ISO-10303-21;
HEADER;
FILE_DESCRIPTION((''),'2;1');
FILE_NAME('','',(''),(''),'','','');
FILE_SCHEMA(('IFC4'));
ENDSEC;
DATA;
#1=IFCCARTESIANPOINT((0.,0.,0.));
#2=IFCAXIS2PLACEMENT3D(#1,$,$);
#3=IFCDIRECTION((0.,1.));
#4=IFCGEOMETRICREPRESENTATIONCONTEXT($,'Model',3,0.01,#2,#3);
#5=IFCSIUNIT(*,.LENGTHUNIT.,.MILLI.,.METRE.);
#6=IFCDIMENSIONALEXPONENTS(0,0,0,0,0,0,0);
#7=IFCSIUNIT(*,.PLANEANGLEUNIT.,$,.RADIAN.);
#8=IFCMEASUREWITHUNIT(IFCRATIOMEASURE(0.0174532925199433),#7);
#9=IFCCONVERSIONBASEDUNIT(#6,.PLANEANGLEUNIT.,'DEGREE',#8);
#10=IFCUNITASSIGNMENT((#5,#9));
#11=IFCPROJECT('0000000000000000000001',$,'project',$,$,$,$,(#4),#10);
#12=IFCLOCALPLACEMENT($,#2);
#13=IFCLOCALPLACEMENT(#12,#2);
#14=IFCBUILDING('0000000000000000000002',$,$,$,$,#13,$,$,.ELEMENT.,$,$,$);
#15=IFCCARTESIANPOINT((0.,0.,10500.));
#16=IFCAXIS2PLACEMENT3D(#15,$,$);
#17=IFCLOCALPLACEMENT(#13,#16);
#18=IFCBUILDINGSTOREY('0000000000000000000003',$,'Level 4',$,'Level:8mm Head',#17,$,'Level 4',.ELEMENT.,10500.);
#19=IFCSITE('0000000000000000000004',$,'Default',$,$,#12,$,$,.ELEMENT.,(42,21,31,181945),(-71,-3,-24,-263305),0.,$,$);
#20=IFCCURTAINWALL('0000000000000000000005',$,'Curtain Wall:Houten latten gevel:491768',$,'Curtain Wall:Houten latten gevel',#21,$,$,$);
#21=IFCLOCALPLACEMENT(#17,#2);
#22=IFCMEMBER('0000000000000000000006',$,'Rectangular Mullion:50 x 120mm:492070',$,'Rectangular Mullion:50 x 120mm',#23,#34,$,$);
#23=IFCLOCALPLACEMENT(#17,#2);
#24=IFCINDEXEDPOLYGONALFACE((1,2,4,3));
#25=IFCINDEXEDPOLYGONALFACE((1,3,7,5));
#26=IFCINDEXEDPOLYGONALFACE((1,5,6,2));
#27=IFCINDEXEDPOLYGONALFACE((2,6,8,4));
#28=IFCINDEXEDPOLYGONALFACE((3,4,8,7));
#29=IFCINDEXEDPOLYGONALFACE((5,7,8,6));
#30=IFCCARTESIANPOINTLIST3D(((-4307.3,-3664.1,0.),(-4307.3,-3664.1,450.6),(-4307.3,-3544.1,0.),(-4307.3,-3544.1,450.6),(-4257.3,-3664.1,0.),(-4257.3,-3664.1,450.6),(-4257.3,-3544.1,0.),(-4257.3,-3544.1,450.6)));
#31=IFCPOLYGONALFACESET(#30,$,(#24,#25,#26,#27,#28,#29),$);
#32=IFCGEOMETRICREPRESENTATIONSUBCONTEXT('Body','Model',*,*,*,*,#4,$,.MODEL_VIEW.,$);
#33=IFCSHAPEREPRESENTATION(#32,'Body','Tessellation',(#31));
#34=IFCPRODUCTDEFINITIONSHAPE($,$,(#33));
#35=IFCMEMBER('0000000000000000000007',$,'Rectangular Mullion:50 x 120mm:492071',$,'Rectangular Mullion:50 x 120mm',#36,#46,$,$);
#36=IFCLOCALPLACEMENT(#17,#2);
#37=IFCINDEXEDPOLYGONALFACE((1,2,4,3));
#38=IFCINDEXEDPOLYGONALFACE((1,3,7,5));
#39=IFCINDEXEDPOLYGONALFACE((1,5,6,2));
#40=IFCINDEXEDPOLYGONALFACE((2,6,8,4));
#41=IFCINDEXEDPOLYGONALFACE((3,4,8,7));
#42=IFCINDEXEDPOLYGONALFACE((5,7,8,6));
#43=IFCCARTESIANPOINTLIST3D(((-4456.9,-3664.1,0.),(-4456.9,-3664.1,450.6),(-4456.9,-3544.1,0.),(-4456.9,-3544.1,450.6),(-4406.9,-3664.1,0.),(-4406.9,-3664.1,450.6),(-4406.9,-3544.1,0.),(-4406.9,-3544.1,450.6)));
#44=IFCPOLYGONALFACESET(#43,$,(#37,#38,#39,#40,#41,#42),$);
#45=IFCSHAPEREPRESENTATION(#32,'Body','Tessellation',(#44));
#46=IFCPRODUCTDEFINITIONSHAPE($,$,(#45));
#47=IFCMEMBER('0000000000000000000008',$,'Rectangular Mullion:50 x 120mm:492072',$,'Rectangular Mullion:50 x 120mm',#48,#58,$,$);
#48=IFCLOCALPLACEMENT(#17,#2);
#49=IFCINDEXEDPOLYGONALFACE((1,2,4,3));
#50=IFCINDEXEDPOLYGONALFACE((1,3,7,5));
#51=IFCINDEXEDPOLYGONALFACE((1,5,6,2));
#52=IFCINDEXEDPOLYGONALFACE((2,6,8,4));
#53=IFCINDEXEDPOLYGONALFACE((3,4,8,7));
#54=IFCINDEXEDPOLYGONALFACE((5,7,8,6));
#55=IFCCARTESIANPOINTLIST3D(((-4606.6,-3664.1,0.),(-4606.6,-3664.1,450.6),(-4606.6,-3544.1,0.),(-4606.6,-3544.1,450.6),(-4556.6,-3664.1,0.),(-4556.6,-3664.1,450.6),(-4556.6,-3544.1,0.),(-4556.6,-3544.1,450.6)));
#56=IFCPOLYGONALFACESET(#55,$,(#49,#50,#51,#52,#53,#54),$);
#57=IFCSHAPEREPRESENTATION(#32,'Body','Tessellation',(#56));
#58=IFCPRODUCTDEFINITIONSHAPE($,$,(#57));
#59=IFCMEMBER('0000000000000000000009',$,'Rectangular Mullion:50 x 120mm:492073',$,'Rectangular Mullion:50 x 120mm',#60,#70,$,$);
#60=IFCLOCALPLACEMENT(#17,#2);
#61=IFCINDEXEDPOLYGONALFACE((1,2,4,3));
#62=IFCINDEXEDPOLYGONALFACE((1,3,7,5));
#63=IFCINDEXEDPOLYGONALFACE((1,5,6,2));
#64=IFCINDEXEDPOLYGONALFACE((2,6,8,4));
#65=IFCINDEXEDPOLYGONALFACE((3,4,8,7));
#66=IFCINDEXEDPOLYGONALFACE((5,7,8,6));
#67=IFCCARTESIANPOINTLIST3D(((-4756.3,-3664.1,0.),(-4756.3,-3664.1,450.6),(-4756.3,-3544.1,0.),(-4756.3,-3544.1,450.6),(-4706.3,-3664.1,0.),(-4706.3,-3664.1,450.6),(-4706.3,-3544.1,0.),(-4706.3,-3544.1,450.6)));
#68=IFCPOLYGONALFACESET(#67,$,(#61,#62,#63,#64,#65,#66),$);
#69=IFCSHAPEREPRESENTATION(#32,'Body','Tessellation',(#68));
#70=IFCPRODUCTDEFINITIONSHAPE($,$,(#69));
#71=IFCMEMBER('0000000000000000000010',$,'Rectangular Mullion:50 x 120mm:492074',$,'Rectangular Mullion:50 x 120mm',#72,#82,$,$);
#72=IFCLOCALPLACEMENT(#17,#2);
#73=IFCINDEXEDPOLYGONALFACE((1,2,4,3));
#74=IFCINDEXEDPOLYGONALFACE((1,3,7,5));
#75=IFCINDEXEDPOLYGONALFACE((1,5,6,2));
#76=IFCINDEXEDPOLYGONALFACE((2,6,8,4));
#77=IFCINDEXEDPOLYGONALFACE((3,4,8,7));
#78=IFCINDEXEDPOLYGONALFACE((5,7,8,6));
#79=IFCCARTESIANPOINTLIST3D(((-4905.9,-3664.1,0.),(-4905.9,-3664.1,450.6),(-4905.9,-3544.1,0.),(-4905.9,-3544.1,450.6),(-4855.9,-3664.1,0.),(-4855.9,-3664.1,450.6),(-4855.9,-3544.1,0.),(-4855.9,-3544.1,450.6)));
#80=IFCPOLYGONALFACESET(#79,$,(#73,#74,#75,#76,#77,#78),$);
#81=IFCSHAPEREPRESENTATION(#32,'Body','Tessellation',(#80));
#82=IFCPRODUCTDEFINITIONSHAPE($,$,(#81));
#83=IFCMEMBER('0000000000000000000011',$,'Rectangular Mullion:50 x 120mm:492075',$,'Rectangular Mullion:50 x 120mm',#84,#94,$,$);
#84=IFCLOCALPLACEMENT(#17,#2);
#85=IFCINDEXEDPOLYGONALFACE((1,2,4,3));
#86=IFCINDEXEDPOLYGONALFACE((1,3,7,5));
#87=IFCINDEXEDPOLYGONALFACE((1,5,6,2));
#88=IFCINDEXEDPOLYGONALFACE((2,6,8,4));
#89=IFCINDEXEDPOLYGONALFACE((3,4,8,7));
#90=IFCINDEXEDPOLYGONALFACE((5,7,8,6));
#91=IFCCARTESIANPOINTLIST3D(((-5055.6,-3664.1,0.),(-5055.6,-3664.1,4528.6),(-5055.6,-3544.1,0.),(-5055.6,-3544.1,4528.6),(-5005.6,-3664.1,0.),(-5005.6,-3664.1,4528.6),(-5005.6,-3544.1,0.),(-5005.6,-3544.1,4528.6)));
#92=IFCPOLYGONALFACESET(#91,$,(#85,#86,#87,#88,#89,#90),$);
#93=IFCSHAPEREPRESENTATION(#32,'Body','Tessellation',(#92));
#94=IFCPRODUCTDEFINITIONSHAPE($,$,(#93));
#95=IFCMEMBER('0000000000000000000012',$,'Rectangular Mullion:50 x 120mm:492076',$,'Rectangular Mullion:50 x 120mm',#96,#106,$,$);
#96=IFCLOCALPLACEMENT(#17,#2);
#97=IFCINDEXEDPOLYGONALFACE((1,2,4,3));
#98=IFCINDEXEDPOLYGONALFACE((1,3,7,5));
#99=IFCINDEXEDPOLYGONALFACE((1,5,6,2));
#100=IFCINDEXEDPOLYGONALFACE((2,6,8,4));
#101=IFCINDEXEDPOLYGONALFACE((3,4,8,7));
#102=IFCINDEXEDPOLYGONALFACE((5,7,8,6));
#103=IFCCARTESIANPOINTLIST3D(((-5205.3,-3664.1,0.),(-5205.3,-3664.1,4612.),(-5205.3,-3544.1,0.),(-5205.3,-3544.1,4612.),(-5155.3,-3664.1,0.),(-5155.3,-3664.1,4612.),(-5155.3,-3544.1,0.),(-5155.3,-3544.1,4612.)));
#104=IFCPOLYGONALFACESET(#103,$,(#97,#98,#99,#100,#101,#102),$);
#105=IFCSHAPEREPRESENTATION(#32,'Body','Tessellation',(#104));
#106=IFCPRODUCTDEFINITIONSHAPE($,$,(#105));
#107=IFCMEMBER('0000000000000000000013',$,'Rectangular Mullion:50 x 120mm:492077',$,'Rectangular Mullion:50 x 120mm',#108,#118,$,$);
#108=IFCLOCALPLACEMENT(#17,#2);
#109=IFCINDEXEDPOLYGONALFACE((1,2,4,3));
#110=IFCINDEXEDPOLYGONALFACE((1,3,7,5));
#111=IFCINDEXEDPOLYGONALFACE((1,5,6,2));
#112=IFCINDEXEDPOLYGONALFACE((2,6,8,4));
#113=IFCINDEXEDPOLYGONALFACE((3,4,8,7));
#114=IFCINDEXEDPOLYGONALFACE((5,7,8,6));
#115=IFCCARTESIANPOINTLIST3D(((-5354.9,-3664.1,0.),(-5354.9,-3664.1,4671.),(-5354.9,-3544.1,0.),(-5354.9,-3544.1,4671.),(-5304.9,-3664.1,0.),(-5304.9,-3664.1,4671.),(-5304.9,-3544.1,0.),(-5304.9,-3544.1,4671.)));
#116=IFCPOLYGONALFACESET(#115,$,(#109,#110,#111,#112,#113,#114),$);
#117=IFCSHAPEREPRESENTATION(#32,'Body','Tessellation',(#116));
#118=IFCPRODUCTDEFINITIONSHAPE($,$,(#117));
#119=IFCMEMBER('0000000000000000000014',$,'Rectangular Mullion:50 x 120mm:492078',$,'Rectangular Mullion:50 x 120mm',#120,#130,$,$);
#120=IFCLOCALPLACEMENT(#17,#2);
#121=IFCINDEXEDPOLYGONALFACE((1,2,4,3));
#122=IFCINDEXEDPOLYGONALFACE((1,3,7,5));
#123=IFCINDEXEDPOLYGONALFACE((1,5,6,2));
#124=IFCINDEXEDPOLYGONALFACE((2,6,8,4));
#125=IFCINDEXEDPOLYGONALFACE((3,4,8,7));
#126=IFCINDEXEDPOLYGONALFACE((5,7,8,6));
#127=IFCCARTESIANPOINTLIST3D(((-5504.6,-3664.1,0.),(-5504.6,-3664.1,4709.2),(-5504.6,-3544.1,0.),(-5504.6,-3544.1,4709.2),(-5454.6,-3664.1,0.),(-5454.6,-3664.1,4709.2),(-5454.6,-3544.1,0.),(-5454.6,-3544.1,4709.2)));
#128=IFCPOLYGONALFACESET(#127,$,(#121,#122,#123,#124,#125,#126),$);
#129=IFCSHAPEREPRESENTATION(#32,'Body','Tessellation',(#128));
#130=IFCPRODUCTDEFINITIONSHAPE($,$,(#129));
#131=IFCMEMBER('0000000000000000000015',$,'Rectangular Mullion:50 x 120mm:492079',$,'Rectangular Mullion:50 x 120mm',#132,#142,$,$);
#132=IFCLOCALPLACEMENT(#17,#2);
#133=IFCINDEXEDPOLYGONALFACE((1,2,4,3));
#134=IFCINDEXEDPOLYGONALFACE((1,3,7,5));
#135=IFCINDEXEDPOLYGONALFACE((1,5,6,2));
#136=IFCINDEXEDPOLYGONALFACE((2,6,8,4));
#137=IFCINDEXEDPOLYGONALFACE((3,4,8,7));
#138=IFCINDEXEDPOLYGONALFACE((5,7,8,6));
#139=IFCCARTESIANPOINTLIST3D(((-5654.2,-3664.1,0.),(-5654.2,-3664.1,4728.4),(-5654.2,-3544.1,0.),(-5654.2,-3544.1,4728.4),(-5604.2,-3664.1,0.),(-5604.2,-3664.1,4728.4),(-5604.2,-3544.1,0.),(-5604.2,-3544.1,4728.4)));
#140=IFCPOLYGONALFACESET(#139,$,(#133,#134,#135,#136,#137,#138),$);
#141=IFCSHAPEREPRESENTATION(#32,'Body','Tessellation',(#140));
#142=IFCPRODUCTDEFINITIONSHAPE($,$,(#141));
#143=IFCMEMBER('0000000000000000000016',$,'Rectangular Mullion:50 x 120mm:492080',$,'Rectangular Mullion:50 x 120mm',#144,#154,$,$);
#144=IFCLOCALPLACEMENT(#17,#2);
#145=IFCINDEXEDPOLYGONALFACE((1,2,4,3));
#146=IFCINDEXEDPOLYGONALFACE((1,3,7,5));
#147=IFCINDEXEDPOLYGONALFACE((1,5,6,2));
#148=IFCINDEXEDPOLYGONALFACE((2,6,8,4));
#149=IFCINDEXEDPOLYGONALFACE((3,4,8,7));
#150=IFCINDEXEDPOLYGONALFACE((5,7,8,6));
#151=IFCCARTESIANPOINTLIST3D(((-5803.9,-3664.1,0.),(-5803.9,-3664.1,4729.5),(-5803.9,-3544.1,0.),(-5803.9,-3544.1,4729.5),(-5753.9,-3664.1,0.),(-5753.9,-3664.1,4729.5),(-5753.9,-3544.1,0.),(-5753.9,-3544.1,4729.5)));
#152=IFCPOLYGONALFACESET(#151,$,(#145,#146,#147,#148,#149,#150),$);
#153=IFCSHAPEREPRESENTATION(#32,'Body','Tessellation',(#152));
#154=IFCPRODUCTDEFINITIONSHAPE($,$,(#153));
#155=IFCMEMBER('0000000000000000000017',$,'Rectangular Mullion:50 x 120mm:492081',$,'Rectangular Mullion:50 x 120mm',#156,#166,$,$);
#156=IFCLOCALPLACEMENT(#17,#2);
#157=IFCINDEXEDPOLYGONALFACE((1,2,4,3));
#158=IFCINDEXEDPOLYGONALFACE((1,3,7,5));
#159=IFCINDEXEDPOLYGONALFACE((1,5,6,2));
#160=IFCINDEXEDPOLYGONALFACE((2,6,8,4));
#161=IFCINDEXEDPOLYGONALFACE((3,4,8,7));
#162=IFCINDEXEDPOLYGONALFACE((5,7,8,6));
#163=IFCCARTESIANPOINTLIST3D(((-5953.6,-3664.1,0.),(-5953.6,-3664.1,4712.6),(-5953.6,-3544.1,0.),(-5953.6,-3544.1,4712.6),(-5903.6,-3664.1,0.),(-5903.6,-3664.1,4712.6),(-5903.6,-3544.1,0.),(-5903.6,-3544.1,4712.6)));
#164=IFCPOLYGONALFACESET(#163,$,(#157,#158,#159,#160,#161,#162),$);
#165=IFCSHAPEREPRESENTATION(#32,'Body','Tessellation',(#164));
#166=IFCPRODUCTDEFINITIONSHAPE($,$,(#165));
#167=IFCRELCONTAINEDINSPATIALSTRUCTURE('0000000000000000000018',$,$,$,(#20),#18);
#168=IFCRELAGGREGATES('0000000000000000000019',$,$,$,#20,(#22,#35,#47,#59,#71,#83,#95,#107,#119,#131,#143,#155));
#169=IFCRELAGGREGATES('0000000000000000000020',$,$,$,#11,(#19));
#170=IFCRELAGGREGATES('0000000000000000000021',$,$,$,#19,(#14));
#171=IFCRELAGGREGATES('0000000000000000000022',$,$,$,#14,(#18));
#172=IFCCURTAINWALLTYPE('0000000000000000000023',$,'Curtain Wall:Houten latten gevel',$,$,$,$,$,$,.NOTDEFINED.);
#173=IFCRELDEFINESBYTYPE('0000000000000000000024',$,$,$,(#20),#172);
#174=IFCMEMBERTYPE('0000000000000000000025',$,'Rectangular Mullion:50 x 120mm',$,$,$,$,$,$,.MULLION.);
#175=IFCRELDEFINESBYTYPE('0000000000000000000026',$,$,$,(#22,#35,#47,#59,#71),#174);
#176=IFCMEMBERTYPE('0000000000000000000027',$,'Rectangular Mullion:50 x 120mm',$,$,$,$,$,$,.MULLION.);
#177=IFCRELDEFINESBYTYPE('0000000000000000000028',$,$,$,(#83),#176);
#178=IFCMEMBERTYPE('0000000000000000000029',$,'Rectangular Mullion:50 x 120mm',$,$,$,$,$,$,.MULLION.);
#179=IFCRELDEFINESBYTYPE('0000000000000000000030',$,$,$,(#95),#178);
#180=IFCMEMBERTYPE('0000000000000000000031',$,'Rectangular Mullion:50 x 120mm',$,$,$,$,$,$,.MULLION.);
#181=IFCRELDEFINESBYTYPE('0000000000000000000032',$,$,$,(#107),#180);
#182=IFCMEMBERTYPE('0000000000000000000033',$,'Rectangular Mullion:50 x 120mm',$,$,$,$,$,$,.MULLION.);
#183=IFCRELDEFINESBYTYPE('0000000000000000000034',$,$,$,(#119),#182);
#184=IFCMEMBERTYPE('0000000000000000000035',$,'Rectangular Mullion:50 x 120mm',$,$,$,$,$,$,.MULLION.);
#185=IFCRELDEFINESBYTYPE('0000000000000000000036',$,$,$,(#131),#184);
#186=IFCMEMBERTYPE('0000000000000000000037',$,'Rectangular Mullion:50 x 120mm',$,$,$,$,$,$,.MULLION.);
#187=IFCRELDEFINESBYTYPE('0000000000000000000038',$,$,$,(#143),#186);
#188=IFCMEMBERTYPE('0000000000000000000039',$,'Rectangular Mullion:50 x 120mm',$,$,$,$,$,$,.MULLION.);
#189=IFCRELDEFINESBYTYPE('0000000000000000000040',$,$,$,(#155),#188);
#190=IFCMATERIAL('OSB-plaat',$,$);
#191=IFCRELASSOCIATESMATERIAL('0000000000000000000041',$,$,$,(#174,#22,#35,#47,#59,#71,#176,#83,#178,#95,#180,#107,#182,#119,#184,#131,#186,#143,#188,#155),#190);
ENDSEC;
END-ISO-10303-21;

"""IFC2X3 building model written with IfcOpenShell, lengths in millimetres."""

from ifc_helpers import new_model, entity, si_unit, converted_unit, direction, frame, origin, origin_2d_with_axis, place, context, subcontext, project, spatial, rectangle, extrude, source, transform, mapped, material, type_object, type_shapes, element, aggregate, save


model = new_model("IFC2X3")

# Units and contexts
model_context = context("Model", 3, precision=0.01, world=origin(), true_north=direction((0.0, 1.0)))
body_context = subcontext(model_context, "Body", "Model", "MODEL_VIEW")
ifc_project = project(units=[si_unit("LENGTHUNIT", "METRE", prefix="MILLI"), converted_unit("PLANEANGLEUNIT", "DEGREE", entity("IfcRatioMeasure", 0.0174532925199433), si_unit("PLANEANGLEUNIT", "RADIAN"), dimensions=[0, 0, 0, 0, 0, 0, 0])], contexts=[model_context])

# Site, building, storey
site_placement = place(None, frame((0.0, 0.0, 0.0)))
site = spatial("IfcSite", under=ifc_project, at=site_placement, Name="Default", CompositionType="ELEMENT", RefLatitude=(42, 21, 31, 181945), RefLongitude=(-71, -3, -24, -263305), RefElevation=0.0)
building_placement = place(site_placement, origin())
building = spatial("IfcBuilding", under=site, at=building_placement, CompositionType="ELEMENT")
storey_placement = place(building_placement, frame((0.0, 0.0, 10500.0)))
storey = spatial("IfcBuildingStorey", under=building, at=storey_placement, Name="Level 4", ObjectType="Level:8mm Head", LongName="Level 4", CompositionType="ELEMENT", Elevation=10500.0)

# Curtain wall, members
curtain_wall_type = type_object("IfcCurtainWallType", Name="Curtain Wall:Houten latten gevel", PredefinedType="NOTDEFINED")
curtain_wall_placement = place(storey_placement, frame((0.0, 0.0, -10500.0)))
curtain_wall = element("IfcCurtainWall", 1, at=curtain_wall_placement, inside=storey, type_object=curtain_wall_type, Name="Curtain Wall:Houten latten gevel:491768", ObjectType="Curtain Wall:Houten latten gevel")
ifc_material_1 = material(Name="OSB-plaat")
member_type_1 = type_object("IfcMemberType", Name="Rectangular Mullion:50 x 120mm", PredefinedType="MULLION", material=ifc_material_1)
shared_shape_1 = source(origin(), body_context, "Body", "SweptSolid", [
    extrude(rectangle(XDim=120.0, YDim=50.0, at=origin_2d_with_axis()), frame((0.0, 0.0, -450.6), z_axis=(0.0, 0.0, 1.0), x_axis=(0.0, -1.0, 0.0)), (0.0, 0.0, 1.0), 450.6),
])
type_shapes(member_type_1, [shared_shape_1])
placement = place(building_placement, frame((0.0, 0.0, 7500.0)))
member_1_placement = place(placement, frame((-4282.3, -3604.1, 3000.0), z_axis=(0.0, 0.0, -1.0), x_axis=(-1.0, 0.0, 0.0)))
member_1 = element("IfcMember", 2, at=member_1_placement, type_object=member_type_1, material=ifc_material_1, Name="Rectangular Mullion:50 x 120mm:492070", ObjectType="Rectangular Mullion:50 x 120mm", context=body_context, shape_type="MappedRepresentation", body=[
    mapped(shared_shape_1, transform((0.0, 0.0, 0.0), scale=1.0)),
])
member_2_placement = place(placement, frame((-4431.9, -3604.1, 3000.0), z_axis=(0.0, 0.0, -1.0), x_axis=(-1.0, 0.0, 0.0)))
member_2 = element("IfcMember", 3, at=member_2_placement, type_object=member_type_1, material=ifc_material_1, Name="Rectangular Mullion:50 x 120mm:492071", ObjectType="Rectangular Mullion:50 x 120mm", context=body_context, shape_type="MappedRepresentation", body=[
    mapped(shared_shape_1, transform((0.0, 0.0, 0.0), scale=1.0)),
])
member_3_placement = place(placement, frame((-4581.6, -3604.1, 3000.0), z_axis=(0.0, 0.0, -1.0), x_axis=(-1.0, 0.0, 0.0)))
member_3 = element("IfcMember", 4, at=member_3_placement, type_object=member_type_1, material=ifc_material_1, Name="Rectangular Mullion:50 x 120mm:492072", ObjectType="Rectangular Mullion:50 x 120mm", context=body_context, shape_type="MappedRepresentation", body=[
    mapped(shared_shape_1, transform((0.0, 0.0, 0.0), scale=1.0)),
])
member_4_placement = place(placement, frame((-4731.3, -3604.1, 3000.0), z_axis=(0.0, 0.0, -1.0), x_axis=(-1.0, 0.0, 0.0)))
member_4 = element("IfcMember", 5, at=member_4_placement, type_object=member_type_1, material=ifc_material_1, Name="Rectangular Mullion:50 x 120mm:492073", ObjectType="Rectangular Mullion:50 x 120mm", context=body_context, shape_type="MappedRepresentation", body=[
    mapped(shared_shape_1, transform((0.0, 0.0, 0.0), scale=1.0)),
])
member_5_placement = place(placement, frame((-4880.9, -3604.1, 3000.0), z_axis=(0.0, 0.0, -1.0), x_axis=(-1.0, 0.0, 0.0)))
member_5 = element("IfcMember", 6, at=member_5_placement, type_object=member_type_1, material=ifc_material_1, Name="Rectangular Mullion:50 x 120mm:492074", ObjectType="Rectangular Mullion:50 x 120mm", context=body_context, shape_type="MappedRepresentation", body=[
    mapped(shared_shape_1, transform((0.0, 0.0, 0.0), scale=1.0)),
])
member_type_2 = type_object("IfcMemberType", Name="Rectangular Mullion:50 x 120mm", PredefinedType="MULLION", material=ifc_material_1)
shared_shape_2 = source(origin(), body_context, "Body", "SweptSolid", [
    extrude(rectangle(XDim=120.0, YDim=50.0, at=origin_2d_with_axis()), frame((0.0, 0.0, -4528.6), z_axis=(0.0, 0.0, 1.0), x_axis=(0.0, -1.0, 0.0)), (0.0, 0.0, 1.0), 4528.6),
])
type_shapes(member_type_2, [shared_shape_2])
member_6_placement = place(placement, frame((-5030.6, -3604.1, 3000.0), z_axis=(0.0, 0.0, -1.0), x_axis=(-1.0, 0.0, 0.0)))
member_6 = element("IfcMember", 7, at=member_6_placement, type_object=member_type_2, material=ifc_material_1, Name="Rectangular Mullion:50 x 120mm:492075", ObjectType="Rectangular Mullion:50 x 120mm", context=body_context, shape_type="MappedRepresentation", body=[
    mapped(shared_shape_2, transform((0.0, 0.0, 0.0), scale=1.0)),
])
member_type_3 = type_object("IfcMemberType", Name="Rectangular Mullion:50 x 120mm", PredefinedType="MULLION", material=ifc_material_1)
shared_shape_3 = source(origin(), body_context, "Body", "SweptSolid", [
    extrude(rectangle(XDim=120.0, YDim=50.0, at=origin_2d_with_axis()), frame((0.0, 0.0, -4612.0), z_axis=(0.0, 0.0, 1.0), x_axis=(0.0, -1.0, 0.0)), (0.0, 0.0, 1.0), 4612.0),
])
type_shapes(member_type_3, [shared_shape_3])
member_7_placement = place(placement, frame((-5180.3, -3604.1, 3000.0), z_axis=(0.0, 0.0, -1.0), x_axis=(-1.0, 0.0, 0.0)))
member_7 = element("IfcMember", 8, at=member_7_placement, type_object=member_type_3, material=ifc_material_1, Name="Rectangular Mullion:50 x 120mm:492076", ObjectType="Rectangular Mullion:50 x 120mm", context=body_context, shape_type="MappedRepresentation", body=[
    mapped(shared_shape_3, transform((0.0, 0.0, 0.0), scale=1.0)),
])
member_type_4 = type_object("IfcMemberType", Name="Rectangular Mullion:50 x 120mm", PredefinedType="MULLION", material=ifc_material_1)
shared_shape_4 = source(origin(), body_context, "Body", "SweptSolid", [
    extrude(rectangle(XDim=120.0, YDim=50.0, at=origin_2d_with_axis()), frame((0.0, 0.0, -4671.0), z_axis=(0.0, 0.0, 1.0), x_axis=(0.0, -1.0, 0.0)), (0.0, 0.0, 1.0), 4671.0),
])
type_shapes(member_type_4, [shared_shape_4])
member_8_placement = place(placement, frame((-5329.9, -3604.1, 3000.0), z_axis=(0.0, 0.0, -1.0), x_axis=(-1.0, 0.0, 0.0)))
member_8 = element("IfcMember", 9, at=member_8_placement, type_object=member_type_4, material=ifc_material_1, Name="Rectangular Mullion:50 x 120mm:492077", ObjectType="Rectangular Mullion:50 x 120mm", context=body_context, shape_type="MappedRepresentation", body=[
    mapped(shared_shape_4, transform((0.0, 0.0, 0.0), scale=1.0)),
])
member_type_5 = type_object("IfcMemberType", Name="Rectangular Mullion:50 x 120mm", PredefinedType="MULLION", material=ifc_material_1)
shared_shape_5 = source(origin(), body_context, "Body", "SweptSolid", [
    extrude(rectangle(XDim=120.0, YDim=50.0, at=origin_2d_with_axis()), frame((0.0, 0.0, -4709.2), z_axis=(0.0, 0.0, 1.0), x_axis=(0.0, -1.0, 0.0)), (0.0, 0.0, 1.0), 4709.2),
])
type_shapes(member_type_5, [shared_shape_5])
member_9_placement = place(placement, frame((-5479.6, -3604.1, 3000.0), z_axis=(0.0, 0.0, -1.0), x_axis=(-1.0, 0.0, 0.0)))
member_9 = element("IfcMember", 10, at=member_9_placement, type_object=member_type_5, material=ifc_material_1, Name="Rectangular Mullion:50 x 120mm:492078", ObjectType="Rectangular Mullion:50 x 120mm", context=body_context, shape_type="MappedRepresentation", body=[
    mapped(shared_shape_5, transform((0.0, 0.0, 0.0), scale=1.0)),
])
member_type_6 = type_object("IfcMemberType", Name="Rectangular Mullion:50 x 120mm", PredefinedType="MULLION", material=ifc_material_1)
shared_shape_6 = source(origin(), body_context, "Body", "SweptSolid", [
    extrude(rectangle(XDim=120.0, YDim=50.0, at=origin_2d_with_axis()), frame((0.0, 0.0, -4728.4), z_axis=(0.0, 0.0, 1.0), x_axis=(0.0, -1.0, 0.0)), (0.0, 0.0, 1.0), 4728.4),
])
type_shapes(member_type_6, [shared_shape_6])
member_10_placement = place(placement, frame((-5629.2, -3604.1, 3000.0), z_axis=(0.0, 0.0, -1.0), x_axis=(-1.0, 0.0, 0.0)))
member_10 = element("IfcMember", 11, at=member_10_placement, type_object=member_type_6, material=ifc_material_1, Name="Rectangular Mullion:50 x 120mm:492079", ObjectType="Rectangular Mullion:50 x 120mm", context=body_context, shape_type="MappedRepresentation", body=[
    mapped(shared_shape_6, transform((0.0, 0.0, 0.0), scale=1.0)),
])
member_type_7 = type_object("IfcMemberType", Name="Rectangular Mullion:50 x 120mm", PredefinedType="MULLION", material=ifc_material_1)
shared_shape_7 = source(origin(), body_context, "Body", "SweptSolid", [
    extrude(rectangle(XDim=120.0, YDim=50.0, at=origin_2d_with_axis()), frame((0.0, 0.0, -4729.5), z_axis=(0.0, 0.0, 1.0), x_axis=(0.0, -1.0, 0.0)), (0.0, 0.0, 1.0), 4729.5),
])
type_shapes(member_type_7, [shared_shape_7])
member_11_placement = place(placement, frame((-5778.9, -3604.1, 3000.0), z_axis=(0.0, 0.0, -1.0), x_axis=(-1.0, 0.0, 0.0)))
member_11 = element("IfcMember", 12, at=member_11_placement, type_object=member_type_7, material=ifc_material_1, Name="Rectangular Mullion:50 x 120mm:492080", ObjectType="Rectangular Mullion:50 x 120mm", context=body_context, shape_type="MappedRepresentation", body=[
    mapped(shared_shape_7, transform((0.0, 0.0, 0.0), scale=1.0)),
])
member_type_8 = type_object("IfcMemberType", Name="Rectangular Mullion:50 x 120mm", PredefinedType="MULLION", material=ifc_material_1)
shared_shape_8 = source(origin(), body_context, "Body", "SweptSolid", [
    extrude(rectangle(XDim=120.0, YDim=50.0, at=origin_2d_with_axis()), frame((0.0, 0.0, -4712.6), z_axis=(0.0, 0.0, 1.0), x_axis=(0.0, -1.0, 0.0)), (0.0, 0.0, 1.0), 4712.6),
])
type_shapes(member_type_8, [shared_shape_8])
member_12_placement = place(placement, frame((-5928.6, -3604.1, 3000.0), z_axis=(0.0, 0.0, -1.0), x_axis=(-1.0, 0.0, 0.0)))
member_12 = element("IfcMember", 13, at=member_12_placement, type_object=member_type_8, material=ifc_material_1, Name="Rectangular Mullion:50 x 120mm:492081", ObjectType="Rectangular Mullion:50 x 120mm", context=body_context, shape_type="MappedRepresentation", body=[
    mapped(shared_shape_8, transform((0.0, 0.0, 0.0), scale=1.0)),
])
aggregate(curtain_wall, [member_1, member_2, member_3, member_4, member_5, member_6, member_7, member_8, member_9, member_10, member_11, member_12])

save(model, "model.ifc")
